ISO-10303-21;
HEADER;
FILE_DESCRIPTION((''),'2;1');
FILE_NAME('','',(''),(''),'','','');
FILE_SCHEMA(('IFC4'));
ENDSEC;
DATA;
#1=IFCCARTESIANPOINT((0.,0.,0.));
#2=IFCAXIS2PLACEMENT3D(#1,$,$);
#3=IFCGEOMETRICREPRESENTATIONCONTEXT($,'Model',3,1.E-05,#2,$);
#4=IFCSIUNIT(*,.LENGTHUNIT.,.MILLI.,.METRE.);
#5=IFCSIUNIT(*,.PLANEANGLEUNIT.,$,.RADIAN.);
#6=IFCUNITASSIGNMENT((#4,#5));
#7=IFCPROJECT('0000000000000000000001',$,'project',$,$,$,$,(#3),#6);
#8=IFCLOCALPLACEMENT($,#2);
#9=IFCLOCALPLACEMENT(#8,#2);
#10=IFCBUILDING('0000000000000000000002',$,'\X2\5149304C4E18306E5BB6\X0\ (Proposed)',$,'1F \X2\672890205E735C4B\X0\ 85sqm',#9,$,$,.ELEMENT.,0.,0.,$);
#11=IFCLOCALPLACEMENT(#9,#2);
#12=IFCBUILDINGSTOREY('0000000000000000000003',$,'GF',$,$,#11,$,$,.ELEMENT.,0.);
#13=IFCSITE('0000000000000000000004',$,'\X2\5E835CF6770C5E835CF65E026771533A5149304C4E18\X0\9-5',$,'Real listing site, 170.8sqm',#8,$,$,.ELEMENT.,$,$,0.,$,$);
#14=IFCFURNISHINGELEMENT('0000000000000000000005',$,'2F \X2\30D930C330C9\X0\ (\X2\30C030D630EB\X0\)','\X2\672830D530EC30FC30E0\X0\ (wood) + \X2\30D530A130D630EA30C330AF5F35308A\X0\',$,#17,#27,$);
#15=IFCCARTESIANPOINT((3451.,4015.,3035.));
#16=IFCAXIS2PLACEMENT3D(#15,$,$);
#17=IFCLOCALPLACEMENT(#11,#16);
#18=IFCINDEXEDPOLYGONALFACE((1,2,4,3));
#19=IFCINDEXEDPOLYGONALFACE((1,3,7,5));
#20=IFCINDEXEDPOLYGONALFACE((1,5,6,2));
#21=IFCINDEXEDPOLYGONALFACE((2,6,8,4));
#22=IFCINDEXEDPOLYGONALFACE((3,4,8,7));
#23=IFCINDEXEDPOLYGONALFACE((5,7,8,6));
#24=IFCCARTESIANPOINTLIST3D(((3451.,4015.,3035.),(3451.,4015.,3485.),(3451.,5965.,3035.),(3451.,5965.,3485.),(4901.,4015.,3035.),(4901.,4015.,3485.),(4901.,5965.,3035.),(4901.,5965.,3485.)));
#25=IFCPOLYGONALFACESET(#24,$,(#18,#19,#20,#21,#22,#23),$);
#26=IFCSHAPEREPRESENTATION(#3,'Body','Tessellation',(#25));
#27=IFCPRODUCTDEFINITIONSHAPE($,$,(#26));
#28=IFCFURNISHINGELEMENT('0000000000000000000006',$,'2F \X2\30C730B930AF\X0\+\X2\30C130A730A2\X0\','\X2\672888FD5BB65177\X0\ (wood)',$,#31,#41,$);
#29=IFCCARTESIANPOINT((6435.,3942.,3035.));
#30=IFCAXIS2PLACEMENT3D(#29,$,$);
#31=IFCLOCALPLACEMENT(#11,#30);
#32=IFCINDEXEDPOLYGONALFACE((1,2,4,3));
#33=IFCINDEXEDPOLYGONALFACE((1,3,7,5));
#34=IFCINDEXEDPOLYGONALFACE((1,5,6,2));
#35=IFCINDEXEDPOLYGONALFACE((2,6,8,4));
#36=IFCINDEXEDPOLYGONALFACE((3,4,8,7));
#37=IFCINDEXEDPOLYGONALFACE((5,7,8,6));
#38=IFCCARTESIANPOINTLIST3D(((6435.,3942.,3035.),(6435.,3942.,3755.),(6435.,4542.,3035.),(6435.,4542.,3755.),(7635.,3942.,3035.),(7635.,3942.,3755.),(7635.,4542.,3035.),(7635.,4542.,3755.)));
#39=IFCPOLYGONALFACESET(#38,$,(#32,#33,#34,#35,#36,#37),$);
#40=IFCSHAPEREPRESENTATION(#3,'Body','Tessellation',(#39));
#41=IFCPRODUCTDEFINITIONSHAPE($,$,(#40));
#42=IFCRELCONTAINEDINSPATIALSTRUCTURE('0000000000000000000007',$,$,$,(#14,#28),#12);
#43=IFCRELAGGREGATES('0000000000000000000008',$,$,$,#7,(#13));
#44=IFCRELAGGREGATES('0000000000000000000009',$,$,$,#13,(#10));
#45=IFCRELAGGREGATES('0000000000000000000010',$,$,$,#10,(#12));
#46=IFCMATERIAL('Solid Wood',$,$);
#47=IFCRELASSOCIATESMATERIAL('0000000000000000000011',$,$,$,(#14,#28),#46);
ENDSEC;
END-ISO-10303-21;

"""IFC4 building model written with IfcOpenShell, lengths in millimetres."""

from ifc_helpers import new_model, si_unit, frame, frame_2d, origin, place, context, project, spatial, rectangle, extrude, material, element, save


model = new_model("IFC4")

# Units and contexts
model_context = context("Model", 3, precision=1e-05, world=origin())
ifc_project = project(units=[si_unit("LENGTHUNIT", "METRE", prefix="MILLI"), si_unit("PLANEANGLEUNIT", "RADIAN")], contexts=[model_context])

# Site, building, storey
site_placement = place(None, origin())
site = spatial("IfcSite", under=ifc_project, at=site_placement, Name="広島県広島市東区光が丘9-5", ObjectType="Real listing site, 170.8sqm", CompositionType="ELEMENT", RefElevation=0.0)
building_placement = place(site_placement, origin())
building = spatial("IfcBuilding", under=site, at=building_placement, Name="光が丘の家 (Proposed)", ObjectType="1F 木造平屋 85sqm", CompositionType="ELEMENT", ElevationOfRefHeight=0.0, ElevationOfTerrain=0.0)
storey_placement = place(building_placement, origin())
storey = spatial("IfcBuildingStorey", under=building, at=storey_placement, Name="GF", CompositionType="ELEMENT", Elevation=0.0)

# Shared definitions
ifc_material_1 = material(Name="Solid Wood")

# Furnishing elements
furnishing_1_placement = place(storey_placement, frame((3451.0, 4015.0, 3035.0)))
element("IfcFurnishingElement", 1, at=furnishing_1_placement, inside=storey, material=ifc_material_1, Name="2F ベッド (ダブル)", Description="木フレーム (wood) + ファブリック張り", context=model_context, shape_type="SweptSolid", body=[
    extrude(rectangle(XDim=1450.0, YDim=1950.0, at=frame_2d((725.0, 975.0))), frame((3451.0, 4015.0, 3035.0)), (0.0, 0.0, 1.0), 450.0),
])
furnishing_2_placement = place(storey_placement, frame((6435.0, 3942.0, 3035.0)))
element("IfcFurnishingElement", 2, at=furnishing_2_placement, inside=storey, material=ifc_material_1, Name="2F デスク+チェア", Description="木製家具 (wood)", context=model_context, shape_type="SweptSolid", body=[
    extrude(rectangle(XDim=1200.0, YDim=600.0, at=frame_2d((600.0, 300.0))), frame((6435.0, 3942.0, 3035.0)), (0.0, 0.0, 1.0), 720.0),
])

save(model, "model.ifc")
